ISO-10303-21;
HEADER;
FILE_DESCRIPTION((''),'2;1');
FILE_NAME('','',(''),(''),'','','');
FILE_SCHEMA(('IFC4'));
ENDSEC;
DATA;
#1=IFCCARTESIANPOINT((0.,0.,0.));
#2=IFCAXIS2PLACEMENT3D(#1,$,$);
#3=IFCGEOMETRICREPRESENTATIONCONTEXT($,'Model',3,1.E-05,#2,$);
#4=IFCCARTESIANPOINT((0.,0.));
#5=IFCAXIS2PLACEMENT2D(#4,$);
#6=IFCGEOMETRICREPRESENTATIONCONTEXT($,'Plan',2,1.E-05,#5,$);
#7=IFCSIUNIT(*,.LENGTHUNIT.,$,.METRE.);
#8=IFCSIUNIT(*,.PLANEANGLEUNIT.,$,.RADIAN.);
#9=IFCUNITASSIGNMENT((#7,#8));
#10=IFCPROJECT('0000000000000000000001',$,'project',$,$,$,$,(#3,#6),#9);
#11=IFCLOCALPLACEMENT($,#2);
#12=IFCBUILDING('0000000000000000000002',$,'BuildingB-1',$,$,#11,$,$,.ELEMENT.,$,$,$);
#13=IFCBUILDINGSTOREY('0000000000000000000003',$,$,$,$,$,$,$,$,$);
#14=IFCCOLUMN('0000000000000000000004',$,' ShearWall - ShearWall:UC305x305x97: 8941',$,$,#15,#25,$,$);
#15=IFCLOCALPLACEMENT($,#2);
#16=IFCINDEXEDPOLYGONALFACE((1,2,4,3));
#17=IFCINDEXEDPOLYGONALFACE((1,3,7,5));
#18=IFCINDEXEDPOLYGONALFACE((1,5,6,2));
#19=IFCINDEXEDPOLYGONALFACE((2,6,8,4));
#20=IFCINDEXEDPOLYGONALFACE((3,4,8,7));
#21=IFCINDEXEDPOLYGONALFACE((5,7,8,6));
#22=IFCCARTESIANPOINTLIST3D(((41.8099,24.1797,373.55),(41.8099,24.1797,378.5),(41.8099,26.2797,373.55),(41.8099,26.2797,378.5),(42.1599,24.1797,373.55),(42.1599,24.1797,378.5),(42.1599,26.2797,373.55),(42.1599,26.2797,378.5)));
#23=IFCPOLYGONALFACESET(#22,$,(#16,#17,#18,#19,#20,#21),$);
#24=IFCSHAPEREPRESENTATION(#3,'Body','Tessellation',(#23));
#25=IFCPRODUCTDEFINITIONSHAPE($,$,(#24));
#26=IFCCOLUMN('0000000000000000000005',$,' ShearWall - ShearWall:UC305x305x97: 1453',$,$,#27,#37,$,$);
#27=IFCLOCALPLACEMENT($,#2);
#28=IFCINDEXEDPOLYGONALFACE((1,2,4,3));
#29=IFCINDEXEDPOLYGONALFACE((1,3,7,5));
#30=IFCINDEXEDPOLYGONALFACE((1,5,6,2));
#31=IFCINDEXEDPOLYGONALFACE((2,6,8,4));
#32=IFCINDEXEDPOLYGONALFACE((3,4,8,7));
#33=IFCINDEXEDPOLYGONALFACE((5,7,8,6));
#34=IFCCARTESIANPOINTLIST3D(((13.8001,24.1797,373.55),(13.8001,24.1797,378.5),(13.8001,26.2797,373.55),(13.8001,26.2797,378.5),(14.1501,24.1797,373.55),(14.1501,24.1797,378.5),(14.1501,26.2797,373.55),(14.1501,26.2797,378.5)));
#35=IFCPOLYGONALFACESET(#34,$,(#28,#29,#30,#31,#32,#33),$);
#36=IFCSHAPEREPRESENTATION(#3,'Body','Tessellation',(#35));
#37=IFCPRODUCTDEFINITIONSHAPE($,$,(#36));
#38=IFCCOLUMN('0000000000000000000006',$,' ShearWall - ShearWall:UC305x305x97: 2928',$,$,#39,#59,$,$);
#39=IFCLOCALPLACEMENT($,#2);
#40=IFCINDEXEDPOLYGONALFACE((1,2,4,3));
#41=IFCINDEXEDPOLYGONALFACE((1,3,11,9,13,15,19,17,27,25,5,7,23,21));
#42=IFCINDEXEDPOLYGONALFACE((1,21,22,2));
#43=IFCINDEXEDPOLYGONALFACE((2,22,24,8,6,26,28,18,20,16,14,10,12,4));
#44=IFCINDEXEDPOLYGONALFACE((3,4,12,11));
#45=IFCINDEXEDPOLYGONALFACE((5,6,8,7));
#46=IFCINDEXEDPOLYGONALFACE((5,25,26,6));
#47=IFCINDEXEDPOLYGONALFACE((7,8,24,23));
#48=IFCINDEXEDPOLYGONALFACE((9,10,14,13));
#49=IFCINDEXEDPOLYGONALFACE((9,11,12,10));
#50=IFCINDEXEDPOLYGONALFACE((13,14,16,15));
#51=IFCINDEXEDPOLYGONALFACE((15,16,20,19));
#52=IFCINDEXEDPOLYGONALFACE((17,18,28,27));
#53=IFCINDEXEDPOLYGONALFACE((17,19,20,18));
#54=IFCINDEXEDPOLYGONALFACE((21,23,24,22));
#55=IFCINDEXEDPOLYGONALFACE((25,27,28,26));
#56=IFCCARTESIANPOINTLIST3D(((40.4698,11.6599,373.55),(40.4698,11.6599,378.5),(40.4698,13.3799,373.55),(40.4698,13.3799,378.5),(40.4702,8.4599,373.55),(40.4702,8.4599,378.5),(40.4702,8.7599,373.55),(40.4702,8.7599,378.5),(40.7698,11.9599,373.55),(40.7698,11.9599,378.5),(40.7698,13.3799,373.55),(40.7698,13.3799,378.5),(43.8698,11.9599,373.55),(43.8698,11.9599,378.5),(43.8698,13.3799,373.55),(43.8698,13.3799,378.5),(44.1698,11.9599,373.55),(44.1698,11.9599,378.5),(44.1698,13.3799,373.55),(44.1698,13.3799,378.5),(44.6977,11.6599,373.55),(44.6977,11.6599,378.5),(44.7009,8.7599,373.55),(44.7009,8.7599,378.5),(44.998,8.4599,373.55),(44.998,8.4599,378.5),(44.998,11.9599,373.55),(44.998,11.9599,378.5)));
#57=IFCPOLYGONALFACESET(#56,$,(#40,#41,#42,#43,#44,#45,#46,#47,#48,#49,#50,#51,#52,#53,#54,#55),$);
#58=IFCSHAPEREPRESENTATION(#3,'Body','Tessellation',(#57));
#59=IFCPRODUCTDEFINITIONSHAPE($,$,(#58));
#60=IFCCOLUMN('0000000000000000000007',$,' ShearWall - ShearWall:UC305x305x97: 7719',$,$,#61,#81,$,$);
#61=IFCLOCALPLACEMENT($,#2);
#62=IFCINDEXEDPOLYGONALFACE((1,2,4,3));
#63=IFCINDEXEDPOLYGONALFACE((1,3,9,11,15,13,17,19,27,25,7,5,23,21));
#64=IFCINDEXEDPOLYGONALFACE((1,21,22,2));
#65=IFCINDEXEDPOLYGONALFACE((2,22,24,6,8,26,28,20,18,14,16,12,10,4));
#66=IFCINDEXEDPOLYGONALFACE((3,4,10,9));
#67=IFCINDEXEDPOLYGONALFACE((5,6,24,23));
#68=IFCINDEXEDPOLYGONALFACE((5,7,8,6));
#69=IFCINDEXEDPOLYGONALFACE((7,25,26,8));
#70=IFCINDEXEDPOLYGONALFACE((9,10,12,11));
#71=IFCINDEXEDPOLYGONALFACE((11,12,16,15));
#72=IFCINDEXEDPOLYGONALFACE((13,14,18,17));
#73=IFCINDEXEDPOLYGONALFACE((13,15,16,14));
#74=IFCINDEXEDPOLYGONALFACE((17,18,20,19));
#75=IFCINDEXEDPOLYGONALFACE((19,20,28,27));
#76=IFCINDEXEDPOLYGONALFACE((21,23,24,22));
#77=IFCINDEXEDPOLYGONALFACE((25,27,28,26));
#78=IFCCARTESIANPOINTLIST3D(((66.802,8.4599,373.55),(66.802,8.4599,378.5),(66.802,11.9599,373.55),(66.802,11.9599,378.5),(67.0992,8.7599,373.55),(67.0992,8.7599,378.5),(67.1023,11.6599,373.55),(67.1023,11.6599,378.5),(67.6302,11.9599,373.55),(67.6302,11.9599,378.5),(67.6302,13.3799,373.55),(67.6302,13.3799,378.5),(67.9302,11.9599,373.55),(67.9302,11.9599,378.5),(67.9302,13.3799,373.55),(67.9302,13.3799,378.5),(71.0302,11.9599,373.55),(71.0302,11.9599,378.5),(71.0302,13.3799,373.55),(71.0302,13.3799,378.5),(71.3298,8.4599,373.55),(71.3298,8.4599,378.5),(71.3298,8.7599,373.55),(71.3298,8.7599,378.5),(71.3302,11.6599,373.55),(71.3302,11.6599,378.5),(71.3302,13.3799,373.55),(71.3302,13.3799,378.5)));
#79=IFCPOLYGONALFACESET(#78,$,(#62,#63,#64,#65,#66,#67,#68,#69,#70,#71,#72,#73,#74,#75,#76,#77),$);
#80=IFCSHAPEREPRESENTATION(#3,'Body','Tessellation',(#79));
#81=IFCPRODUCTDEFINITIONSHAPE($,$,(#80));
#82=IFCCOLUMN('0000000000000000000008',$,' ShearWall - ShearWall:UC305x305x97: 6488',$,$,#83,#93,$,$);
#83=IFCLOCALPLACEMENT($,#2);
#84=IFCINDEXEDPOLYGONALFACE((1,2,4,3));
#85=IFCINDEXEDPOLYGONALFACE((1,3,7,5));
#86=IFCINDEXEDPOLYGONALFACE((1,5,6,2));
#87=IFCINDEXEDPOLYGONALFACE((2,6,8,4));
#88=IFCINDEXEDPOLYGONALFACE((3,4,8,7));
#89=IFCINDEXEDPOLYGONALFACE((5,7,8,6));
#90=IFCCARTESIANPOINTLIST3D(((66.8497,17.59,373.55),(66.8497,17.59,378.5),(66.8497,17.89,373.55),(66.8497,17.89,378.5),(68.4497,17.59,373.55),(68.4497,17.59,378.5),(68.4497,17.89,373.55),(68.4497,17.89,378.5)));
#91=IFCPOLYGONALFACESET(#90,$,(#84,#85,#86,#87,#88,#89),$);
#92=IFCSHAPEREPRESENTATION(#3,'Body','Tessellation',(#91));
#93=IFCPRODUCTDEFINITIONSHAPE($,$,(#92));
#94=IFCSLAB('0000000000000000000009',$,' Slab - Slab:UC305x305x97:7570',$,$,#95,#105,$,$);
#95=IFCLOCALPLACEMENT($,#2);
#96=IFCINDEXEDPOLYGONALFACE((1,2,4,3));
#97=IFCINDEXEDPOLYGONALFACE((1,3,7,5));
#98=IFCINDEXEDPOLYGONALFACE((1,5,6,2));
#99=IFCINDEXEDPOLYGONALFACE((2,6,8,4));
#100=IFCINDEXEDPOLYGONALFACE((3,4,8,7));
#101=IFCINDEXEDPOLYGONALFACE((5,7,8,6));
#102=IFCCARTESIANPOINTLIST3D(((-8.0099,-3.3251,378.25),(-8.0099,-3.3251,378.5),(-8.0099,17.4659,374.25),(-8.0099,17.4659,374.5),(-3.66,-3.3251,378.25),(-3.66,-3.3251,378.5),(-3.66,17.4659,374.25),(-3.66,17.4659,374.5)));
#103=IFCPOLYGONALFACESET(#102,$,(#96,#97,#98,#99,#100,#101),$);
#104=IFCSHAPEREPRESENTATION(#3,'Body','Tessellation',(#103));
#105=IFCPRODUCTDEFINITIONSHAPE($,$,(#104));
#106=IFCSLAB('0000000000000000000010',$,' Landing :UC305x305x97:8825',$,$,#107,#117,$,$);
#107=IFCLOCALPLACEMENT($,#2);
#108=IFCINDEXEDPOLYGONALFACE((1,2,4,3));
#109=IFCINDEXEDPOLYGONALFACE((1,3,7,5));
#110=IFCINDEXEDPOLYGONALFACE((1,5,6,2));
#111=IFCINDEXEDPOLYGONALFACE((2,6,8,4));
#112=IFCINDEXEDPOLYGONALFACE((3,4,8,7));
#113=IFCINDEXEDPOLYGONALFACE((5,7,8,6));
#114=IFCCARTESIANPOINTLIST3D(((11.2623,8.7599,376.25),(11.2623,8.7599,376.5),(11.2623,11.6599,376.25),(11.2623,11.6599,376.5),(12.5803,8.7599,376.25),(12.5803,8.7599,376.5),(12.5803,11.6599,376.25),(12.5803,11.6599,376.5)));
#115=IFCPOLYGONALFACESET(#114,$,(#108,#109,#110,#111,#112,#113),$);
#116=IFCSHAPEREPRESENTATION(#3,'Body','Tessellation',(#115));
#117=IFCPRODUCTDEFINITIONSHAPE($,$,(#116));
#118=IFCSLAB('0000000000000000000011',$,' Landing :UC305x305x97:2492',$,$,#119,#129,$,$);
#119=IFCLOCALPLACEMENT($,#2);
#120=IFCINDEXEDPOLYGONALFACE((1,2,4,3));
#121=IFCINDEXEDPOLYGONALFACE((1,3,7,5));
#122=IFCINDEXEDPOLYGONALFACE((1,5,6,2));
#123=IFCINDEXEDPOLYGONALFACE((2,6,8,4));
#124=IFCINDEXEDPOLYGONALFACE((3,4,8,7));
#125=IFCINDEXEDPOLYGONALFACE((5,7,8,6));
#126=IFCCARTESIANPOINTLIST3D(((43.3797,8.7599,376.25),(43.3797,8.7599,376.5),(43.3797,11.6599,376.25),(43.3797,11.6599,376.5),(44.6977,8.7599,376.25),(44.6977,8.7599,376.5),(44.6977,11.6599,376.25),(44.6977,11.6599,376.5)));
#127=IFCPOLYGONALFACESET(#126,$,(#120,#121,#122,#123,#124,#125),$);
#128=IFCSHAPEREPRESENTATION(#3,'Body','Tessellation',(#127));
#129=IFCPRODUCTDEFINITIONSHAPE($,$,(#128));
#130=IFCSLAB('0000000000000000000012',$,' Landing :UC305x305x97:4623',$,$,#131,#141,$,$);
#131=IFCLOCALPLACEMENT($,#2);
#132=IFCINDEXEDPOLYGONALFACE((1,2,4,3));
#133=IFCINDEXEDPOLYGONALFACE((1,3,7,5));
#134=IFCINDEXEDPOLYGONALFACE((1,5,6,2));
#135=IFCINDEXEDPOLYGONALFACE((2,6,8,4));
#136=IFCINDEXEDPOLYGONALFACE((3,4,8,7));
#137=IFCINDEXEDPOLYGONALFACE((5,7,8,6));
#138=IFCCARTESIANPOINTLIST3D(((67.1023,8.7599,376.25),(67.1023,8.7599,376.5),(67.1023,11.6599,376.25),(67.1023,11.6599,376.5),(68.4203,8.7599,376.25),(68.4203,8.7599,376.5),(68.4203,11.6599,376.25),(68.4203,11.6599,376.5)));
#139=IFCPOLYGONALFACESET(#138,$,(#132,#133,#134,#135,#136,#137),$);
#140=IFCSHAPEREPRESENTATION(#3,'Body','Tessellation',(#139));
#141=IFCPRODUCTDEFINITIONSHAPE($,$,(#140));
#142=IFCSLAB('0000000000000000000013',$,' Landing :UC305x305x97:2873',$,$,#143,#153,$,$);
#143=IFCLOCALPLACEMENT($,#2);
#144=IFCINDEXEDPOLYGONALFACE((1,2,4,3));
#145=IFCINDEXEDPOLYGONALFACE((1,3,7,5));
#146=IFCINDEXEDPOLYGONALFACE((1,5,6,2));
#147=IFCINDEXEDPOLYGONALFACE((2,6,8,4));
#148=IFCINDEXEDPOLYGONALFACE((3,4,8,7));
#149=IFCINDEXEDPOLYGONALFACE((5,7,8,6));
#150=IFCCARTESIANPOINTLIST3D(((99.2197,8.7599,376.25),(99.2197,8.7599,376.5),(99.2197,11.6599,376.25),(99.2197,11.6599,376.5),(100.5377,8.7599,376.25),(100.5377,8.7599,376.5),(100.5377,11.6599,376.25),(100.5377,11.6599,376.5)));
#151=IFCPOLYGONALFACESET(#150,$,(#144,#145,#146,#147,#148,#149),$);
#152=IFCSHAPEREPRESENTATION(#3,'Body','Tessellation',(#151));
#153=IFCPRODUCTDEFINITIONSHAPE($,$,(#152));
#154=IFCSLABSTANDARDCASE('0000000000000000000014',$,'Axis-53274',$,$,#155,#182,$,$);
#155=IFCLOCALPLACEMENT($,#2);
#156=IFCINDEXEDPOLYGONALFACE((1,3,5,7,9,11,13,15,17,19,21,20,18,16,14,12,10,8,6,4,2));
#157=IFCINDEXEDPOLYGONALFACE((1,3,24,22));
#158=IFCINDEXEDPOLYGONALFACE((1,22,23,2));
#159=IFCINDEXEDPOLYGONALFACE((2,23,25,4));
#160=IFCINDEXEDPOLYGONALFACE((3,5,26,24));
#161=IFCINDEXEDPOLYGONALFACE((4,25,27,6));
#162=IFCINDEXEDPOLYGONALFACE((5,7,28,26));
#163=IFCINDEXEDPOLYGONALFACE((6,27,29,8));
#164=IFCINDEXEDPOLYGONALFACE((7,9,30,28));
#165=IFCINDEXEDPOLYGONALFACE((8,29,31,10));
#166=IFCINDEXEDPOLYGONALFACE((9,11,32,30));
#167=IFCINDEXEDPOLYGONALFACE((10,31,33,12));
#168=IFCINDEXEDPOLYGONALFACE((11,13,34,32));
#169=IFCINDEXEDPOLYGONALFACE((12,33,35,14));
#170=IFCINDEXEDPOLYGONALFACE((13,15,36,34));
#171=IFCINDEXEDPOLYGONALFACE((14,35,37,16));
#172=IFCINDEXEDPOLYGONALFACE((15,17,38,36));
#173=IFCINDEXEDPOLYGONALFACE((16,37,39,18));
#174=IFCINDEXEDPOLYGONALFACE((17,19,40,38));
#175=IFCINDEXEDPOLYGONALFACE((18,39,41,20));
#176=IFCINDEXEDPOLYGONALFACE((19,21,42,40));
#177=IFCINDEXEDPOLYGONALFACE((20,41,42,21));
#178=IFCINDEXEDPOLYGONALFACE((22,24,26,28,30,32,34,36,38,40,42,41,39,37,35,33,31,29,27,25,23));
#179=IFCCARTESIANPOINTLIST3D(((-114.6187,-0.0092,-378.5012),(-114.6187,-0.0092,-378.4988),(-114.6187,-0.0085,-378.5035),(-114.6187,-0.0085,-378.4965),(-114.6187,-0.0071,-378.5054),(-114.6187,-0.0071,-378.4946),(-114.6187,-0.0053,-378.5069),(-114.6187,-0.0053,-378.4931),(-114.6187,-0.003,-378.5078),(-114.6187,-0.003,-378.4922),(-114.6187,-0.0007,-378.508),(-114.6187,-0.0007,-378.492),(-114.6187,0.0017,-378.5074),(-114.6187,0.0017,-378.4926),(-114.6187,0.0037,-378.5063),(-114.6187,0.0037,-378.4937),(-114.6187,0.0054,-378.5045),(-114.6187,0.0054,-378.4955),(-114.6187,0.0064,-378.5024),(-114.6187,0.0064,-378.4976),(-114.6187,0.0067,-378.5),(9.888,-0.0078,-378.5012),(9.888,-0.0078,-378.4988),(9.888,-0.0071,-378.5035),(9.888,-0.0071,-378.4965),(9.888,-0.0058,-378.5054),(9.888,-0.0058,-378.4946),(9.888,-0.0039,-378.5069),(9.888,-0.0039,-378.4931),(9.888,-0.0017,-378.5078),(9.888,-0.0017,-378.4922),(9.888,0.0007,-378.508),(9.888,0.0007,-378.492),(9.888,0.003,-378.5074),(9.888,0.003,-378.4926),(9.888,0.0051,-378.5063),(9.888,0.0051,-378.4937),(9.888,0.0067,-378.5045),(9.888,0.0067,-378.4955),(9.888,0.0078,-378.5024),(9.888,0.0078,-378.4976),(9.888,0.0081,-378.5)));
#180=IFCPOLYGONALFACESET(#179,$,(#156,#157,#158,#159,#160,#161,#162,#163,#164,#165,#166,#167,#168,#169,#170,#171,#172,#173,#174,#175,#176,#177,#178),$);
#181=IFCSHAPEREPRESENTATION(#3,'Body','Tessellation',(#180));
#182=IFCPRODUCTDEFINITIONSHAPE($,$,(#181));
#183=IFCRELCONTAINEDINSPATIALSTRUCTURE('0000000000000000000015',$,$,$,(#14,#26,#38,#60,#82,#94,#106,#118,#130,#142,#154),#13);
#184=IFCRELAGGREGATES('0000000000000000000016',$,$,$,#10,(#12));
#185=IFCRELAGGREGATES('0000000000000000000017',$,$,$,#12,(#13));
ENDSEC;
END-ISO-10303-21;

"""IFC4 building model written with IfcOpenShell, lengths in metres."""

from ifc_helpers import new_model, entity, si_unit, origin, origin_with_axes, origin_2d, place, context, project, spatial, polyline, outline, extrude, element, save


model = new_model("IFC4")

# Units and contexts
model_context = context("Model", 3, precision=1e-05, world=origin())
plan_context = context("Plan", 2, precision=1e-05, world=origin_2d())
ifc_project = project(units=[si_unit("LENGTHUNIT", "METRE"), si_unit("PLANEANGLEUNIT", "RADIAN")], contexts=[model_context, plan_context])

# Building, storey
building_placement = place(None, origin())
building = spatial("IfcBuilding", under=ifc_project, at=building_placement, Name="BuildingB-1", CompositionType="ELEMENT")
storey = spatial("IfcBuildingStorey", under=building)

# Columns
column_1_placement = place(None, origin_with_axes())
element("IfcColumn", 1, at=column_1_placement, inside=storey, Name=" ShearWall - ShearWall:UC305x305x97: 8941", context=model_context, shape_type="SweptSolid", body=[
    extrude(outline(polyline([(41.8099, 26.2797, 378.5), (42.1599, 26.2797, 378.5), (42.1599, 24.1797, 378.5), (41.8099, 24.1797, 378.5), (41.8099, 26.2797, 378.5)])), None, (0.0, 0.0, -1.0), 4.95),
])
column_2_placement = place(None, origin_with_axes())
element("IfcColumn", 2, at=column_2_placement, inside=storey, Name=" ShearWall - ShearWall:UC305x305x97: 1453", context=model_context, shape_type="SweptSolid", body=[
    extrude(outline(polyline([(14.1501, 26.2797, 378.5), (13.8001, 26.2797, 378.5), (13.8001, 24.1797, 378.5), (14.1501, 24.1797, 378.5), (14.1501, 26.2797, 378.5)])), None, (0.0, 0.0, -1.0), 4.95),
])
column_3_placement = place(None, origin_with_axes())
element("IfcColumn", 3, at=column_3_placement, inside=storey, Name=" ShearWall - ShearWall:UC305x305x97: 2928", context=model_context, shape_type="SweptSolid", body=[
    extrude(outline(polyline([(44.998, 8.4599, 378.5), (40.4702, 8.4599, 378.5), (40.4702, 8.7599, 378.5), (44.7009, 8.7599, 378.5), (44.6977, 11.6599, 378.5), (40.4698, 11.6599, 378.5), (40.4698, 13.3799, 378.5), (40.7698, 13.3799, 378.5), (40.7698, 11.9599, 378.5), (43.8698, 11.9599, 378.5), (43.8698, 13.3799, 378.5), (44.1698, 13.3799, 378.5), (44.1698, 11.9599, 378.5), (44.998, 11.9599, 378.5), (44.998, 8.4599, 378.5)])), None, (0.0, 0.0, -1.0), 4.95),
])
column_4_placement = place(None, origin_with_axes())
element("IfcColumn", 4, at=column_4_placement, inside=storey, Name=" ShearWall - ShearWall:UC305x305x97: 7719", context=model_context, shape_type="SweptSolid", body=[
    extrude(outline(polyline([(66.802, 8.4599, 378.5), (71.3298, 8.4599, 378.5), (71.3298, 8.7599, 378.5), (67.0992, 8.7599, 378.5), (67.1023, 11.6599, 378.5), (71.3302, 11.6599, 378.5), (71.3302, 13.3799, 378.5), (71.0302, 13.3799, 378.5), (71.0302, 11.9599, 378.5), (67.9302, 11.9599, 378.5), (67.9302, 13.3799, 378.5), (67.6302, 13.3799, 378.5), (67.6302, 11.9599, 378.5), (66.802, 11.9599, 378.5), (66.802, 8.4599, 378.5)])), None, (0.0, 0.0, -1.0), 4.95),
])
column_5_placement = place(None, origin_with_axes())
element("IfcColumn", 5, at=column_5_placement, inside=storey, Name=" ShearWall - ShearWall:UC305x305x97: 6488", context=model_context, shape_type="SweptSolid", body=[
    extrude(outline(polyline([(66.8497, 17.59, 378.5), (66.8497, 17.89, 378.5), (68.4497, 17.89, 378.5), (68.4497, 17.59, 378.5), (66.8497, 17.59, 378.5)])), None, (0.0, 0.0, -1.0), 4.95),
])

# Slabs
element("IfcSlab", 6, inside=storey, Name=" Slab - Slab:UC305x305x97:7570", context=model_context, shape_type="SweptSolid", body=[
    extrude(outline(polyline([(-3.66, -3.3251, 378.5), (-3.66, 17.4659, 374.5), (-8.0099, 17.4659, 374.5), (-8.0099, -3.3251, 378.5), (-3.66, -3.3251, 378.5)])), None, (0.0, 0.0, -1.0), 0.25),
])
element("IfcSlab", 7, inside=storey, Name=" Landing :UC305x305x97:8825", context=model_context, shape_type="SweptSolid", body=[
    extrude(outline(polyline([(11.2623, 11.6599, 376.5), (11.2623, 8.7599, 376.5), (12.5803, 8.7599, 376.5), (12.5803, 11.6599, 376.5), (11.2623, 11.6599, 376.5)])), None, (0.0, 0.0, -1.0), 0.25),
])
element("IfcSlab", 8, inside=storey, Name=" Landing :UC305x305x97:2492", context=model_context, shape_type="SweptSolid", body=[
    extrude(outline(polyline([(44.6977, 11.6599, 376.5), (44.6977, 8.7599, 376.5), (43.3797, 8.7599, 376.5), (43.3797, 11.6599, 376.5), (44.6977, 11.6599, 376.5)])), None, (0.0, 0.0, -1.0), 0.25),
])
element("IfcSlab", 9, inside=storey, Name=" Landing :UC305x305x97:4623", context=model_context, shape_type="SweptSolid", body=[
    extrude(outline(polyline([(67.1023, 11.6599, 376.5), (67.1023, 8.7599, 376.5), (68.4203, 8.7599, 376.5), (68.4203, 11.6599, 376.5), (67.1023, 11.6599, 376.5)])), None, (0.0, 0.0, -1.0), 0.25),
])
element("IfcSlab", 10, inside=storey, Name=" Landing :UC305x305x97:2873", context=model_context, shape_type="SweptSolid", body=[
    extrude(outline(polyline([(100.5377, 11.6599, 376.5), (100.5377, 8.7599, 376.5), (99.2197, 8.7599, 376.5), (99.2197, 11.6599, 376.5), (100.5377, 11.6599, 376.5)])), None, (0.0, 0.0, -1.0), 0.25),
])
element("IfcSlabStandardCase", 11, inside=storey, Name="Axis-53274", context=model_context, shape_type="AdvancedSweptSolid", body=[
    entity("IfcSurfaceCurveSweptAreaSolid", entity("IfcCircleProfileDef", "AREA", None, None, 0.008), None, entity("IfcPolyline", [entity("IfcCartesianPoint", [-9.888, -0.0001, 378.5]), entity("IfcCartesianPoint", [114.6187, 0.0013, 378.5])]), None, None, entity("IfcPlane", entity("IfcAxis2Placement3D", entity("IfcCartesianPoint", [-9.888, -0.0001, 378.5]), entity("IfcDirection", [0.0, 0.0, 1.0]), entity("IfcDirection", [1.0, 0.0, 0.0])))),
    entity("IfcSurfaceCurveSweptAreaSolid", entity("IfcCircleProfileDef", "AREA", None, None, 0.008), None, entity("IfcCircle", entity("IfcAxis2Placement2D", entity("IfcCartesianPoint", [-10.1215, -0.0001, 378.5])), 0.35), None, None, entity("IfcPlane", entity("IfcAxis2Placement3D", entity("IfcCartesianPoint", [-10.1215, -0.0001, 378.5]), entity("IfcDirection", [0.0, 0.0, 1.0]), entity("IfcDirection", [1.0, 0.0, 0.0])))),
    entity("IfcSurfaceCurveSweptAreaSolid", entity("IfcCircleProfileDef", "AREA", None, None, 0.008), None, entity("IfcCircle", entity("IfcAxis2Placement2D", entity("IfcCartesianPoint", [114.8522, 0.0013, 378.5])), 0.35), None, None, entity("IfcPlane", entity("IfcAxis2Placement3D", entity("IfcCartesianPoint", [114.8522, 0.0013, 378.5]), entity("IfcDirection", [0.0, 0.0, 1.0]), entity("IfcDirection", [1.0, 0.0, 0.0])))),
])

save(model, "model.ifc")
